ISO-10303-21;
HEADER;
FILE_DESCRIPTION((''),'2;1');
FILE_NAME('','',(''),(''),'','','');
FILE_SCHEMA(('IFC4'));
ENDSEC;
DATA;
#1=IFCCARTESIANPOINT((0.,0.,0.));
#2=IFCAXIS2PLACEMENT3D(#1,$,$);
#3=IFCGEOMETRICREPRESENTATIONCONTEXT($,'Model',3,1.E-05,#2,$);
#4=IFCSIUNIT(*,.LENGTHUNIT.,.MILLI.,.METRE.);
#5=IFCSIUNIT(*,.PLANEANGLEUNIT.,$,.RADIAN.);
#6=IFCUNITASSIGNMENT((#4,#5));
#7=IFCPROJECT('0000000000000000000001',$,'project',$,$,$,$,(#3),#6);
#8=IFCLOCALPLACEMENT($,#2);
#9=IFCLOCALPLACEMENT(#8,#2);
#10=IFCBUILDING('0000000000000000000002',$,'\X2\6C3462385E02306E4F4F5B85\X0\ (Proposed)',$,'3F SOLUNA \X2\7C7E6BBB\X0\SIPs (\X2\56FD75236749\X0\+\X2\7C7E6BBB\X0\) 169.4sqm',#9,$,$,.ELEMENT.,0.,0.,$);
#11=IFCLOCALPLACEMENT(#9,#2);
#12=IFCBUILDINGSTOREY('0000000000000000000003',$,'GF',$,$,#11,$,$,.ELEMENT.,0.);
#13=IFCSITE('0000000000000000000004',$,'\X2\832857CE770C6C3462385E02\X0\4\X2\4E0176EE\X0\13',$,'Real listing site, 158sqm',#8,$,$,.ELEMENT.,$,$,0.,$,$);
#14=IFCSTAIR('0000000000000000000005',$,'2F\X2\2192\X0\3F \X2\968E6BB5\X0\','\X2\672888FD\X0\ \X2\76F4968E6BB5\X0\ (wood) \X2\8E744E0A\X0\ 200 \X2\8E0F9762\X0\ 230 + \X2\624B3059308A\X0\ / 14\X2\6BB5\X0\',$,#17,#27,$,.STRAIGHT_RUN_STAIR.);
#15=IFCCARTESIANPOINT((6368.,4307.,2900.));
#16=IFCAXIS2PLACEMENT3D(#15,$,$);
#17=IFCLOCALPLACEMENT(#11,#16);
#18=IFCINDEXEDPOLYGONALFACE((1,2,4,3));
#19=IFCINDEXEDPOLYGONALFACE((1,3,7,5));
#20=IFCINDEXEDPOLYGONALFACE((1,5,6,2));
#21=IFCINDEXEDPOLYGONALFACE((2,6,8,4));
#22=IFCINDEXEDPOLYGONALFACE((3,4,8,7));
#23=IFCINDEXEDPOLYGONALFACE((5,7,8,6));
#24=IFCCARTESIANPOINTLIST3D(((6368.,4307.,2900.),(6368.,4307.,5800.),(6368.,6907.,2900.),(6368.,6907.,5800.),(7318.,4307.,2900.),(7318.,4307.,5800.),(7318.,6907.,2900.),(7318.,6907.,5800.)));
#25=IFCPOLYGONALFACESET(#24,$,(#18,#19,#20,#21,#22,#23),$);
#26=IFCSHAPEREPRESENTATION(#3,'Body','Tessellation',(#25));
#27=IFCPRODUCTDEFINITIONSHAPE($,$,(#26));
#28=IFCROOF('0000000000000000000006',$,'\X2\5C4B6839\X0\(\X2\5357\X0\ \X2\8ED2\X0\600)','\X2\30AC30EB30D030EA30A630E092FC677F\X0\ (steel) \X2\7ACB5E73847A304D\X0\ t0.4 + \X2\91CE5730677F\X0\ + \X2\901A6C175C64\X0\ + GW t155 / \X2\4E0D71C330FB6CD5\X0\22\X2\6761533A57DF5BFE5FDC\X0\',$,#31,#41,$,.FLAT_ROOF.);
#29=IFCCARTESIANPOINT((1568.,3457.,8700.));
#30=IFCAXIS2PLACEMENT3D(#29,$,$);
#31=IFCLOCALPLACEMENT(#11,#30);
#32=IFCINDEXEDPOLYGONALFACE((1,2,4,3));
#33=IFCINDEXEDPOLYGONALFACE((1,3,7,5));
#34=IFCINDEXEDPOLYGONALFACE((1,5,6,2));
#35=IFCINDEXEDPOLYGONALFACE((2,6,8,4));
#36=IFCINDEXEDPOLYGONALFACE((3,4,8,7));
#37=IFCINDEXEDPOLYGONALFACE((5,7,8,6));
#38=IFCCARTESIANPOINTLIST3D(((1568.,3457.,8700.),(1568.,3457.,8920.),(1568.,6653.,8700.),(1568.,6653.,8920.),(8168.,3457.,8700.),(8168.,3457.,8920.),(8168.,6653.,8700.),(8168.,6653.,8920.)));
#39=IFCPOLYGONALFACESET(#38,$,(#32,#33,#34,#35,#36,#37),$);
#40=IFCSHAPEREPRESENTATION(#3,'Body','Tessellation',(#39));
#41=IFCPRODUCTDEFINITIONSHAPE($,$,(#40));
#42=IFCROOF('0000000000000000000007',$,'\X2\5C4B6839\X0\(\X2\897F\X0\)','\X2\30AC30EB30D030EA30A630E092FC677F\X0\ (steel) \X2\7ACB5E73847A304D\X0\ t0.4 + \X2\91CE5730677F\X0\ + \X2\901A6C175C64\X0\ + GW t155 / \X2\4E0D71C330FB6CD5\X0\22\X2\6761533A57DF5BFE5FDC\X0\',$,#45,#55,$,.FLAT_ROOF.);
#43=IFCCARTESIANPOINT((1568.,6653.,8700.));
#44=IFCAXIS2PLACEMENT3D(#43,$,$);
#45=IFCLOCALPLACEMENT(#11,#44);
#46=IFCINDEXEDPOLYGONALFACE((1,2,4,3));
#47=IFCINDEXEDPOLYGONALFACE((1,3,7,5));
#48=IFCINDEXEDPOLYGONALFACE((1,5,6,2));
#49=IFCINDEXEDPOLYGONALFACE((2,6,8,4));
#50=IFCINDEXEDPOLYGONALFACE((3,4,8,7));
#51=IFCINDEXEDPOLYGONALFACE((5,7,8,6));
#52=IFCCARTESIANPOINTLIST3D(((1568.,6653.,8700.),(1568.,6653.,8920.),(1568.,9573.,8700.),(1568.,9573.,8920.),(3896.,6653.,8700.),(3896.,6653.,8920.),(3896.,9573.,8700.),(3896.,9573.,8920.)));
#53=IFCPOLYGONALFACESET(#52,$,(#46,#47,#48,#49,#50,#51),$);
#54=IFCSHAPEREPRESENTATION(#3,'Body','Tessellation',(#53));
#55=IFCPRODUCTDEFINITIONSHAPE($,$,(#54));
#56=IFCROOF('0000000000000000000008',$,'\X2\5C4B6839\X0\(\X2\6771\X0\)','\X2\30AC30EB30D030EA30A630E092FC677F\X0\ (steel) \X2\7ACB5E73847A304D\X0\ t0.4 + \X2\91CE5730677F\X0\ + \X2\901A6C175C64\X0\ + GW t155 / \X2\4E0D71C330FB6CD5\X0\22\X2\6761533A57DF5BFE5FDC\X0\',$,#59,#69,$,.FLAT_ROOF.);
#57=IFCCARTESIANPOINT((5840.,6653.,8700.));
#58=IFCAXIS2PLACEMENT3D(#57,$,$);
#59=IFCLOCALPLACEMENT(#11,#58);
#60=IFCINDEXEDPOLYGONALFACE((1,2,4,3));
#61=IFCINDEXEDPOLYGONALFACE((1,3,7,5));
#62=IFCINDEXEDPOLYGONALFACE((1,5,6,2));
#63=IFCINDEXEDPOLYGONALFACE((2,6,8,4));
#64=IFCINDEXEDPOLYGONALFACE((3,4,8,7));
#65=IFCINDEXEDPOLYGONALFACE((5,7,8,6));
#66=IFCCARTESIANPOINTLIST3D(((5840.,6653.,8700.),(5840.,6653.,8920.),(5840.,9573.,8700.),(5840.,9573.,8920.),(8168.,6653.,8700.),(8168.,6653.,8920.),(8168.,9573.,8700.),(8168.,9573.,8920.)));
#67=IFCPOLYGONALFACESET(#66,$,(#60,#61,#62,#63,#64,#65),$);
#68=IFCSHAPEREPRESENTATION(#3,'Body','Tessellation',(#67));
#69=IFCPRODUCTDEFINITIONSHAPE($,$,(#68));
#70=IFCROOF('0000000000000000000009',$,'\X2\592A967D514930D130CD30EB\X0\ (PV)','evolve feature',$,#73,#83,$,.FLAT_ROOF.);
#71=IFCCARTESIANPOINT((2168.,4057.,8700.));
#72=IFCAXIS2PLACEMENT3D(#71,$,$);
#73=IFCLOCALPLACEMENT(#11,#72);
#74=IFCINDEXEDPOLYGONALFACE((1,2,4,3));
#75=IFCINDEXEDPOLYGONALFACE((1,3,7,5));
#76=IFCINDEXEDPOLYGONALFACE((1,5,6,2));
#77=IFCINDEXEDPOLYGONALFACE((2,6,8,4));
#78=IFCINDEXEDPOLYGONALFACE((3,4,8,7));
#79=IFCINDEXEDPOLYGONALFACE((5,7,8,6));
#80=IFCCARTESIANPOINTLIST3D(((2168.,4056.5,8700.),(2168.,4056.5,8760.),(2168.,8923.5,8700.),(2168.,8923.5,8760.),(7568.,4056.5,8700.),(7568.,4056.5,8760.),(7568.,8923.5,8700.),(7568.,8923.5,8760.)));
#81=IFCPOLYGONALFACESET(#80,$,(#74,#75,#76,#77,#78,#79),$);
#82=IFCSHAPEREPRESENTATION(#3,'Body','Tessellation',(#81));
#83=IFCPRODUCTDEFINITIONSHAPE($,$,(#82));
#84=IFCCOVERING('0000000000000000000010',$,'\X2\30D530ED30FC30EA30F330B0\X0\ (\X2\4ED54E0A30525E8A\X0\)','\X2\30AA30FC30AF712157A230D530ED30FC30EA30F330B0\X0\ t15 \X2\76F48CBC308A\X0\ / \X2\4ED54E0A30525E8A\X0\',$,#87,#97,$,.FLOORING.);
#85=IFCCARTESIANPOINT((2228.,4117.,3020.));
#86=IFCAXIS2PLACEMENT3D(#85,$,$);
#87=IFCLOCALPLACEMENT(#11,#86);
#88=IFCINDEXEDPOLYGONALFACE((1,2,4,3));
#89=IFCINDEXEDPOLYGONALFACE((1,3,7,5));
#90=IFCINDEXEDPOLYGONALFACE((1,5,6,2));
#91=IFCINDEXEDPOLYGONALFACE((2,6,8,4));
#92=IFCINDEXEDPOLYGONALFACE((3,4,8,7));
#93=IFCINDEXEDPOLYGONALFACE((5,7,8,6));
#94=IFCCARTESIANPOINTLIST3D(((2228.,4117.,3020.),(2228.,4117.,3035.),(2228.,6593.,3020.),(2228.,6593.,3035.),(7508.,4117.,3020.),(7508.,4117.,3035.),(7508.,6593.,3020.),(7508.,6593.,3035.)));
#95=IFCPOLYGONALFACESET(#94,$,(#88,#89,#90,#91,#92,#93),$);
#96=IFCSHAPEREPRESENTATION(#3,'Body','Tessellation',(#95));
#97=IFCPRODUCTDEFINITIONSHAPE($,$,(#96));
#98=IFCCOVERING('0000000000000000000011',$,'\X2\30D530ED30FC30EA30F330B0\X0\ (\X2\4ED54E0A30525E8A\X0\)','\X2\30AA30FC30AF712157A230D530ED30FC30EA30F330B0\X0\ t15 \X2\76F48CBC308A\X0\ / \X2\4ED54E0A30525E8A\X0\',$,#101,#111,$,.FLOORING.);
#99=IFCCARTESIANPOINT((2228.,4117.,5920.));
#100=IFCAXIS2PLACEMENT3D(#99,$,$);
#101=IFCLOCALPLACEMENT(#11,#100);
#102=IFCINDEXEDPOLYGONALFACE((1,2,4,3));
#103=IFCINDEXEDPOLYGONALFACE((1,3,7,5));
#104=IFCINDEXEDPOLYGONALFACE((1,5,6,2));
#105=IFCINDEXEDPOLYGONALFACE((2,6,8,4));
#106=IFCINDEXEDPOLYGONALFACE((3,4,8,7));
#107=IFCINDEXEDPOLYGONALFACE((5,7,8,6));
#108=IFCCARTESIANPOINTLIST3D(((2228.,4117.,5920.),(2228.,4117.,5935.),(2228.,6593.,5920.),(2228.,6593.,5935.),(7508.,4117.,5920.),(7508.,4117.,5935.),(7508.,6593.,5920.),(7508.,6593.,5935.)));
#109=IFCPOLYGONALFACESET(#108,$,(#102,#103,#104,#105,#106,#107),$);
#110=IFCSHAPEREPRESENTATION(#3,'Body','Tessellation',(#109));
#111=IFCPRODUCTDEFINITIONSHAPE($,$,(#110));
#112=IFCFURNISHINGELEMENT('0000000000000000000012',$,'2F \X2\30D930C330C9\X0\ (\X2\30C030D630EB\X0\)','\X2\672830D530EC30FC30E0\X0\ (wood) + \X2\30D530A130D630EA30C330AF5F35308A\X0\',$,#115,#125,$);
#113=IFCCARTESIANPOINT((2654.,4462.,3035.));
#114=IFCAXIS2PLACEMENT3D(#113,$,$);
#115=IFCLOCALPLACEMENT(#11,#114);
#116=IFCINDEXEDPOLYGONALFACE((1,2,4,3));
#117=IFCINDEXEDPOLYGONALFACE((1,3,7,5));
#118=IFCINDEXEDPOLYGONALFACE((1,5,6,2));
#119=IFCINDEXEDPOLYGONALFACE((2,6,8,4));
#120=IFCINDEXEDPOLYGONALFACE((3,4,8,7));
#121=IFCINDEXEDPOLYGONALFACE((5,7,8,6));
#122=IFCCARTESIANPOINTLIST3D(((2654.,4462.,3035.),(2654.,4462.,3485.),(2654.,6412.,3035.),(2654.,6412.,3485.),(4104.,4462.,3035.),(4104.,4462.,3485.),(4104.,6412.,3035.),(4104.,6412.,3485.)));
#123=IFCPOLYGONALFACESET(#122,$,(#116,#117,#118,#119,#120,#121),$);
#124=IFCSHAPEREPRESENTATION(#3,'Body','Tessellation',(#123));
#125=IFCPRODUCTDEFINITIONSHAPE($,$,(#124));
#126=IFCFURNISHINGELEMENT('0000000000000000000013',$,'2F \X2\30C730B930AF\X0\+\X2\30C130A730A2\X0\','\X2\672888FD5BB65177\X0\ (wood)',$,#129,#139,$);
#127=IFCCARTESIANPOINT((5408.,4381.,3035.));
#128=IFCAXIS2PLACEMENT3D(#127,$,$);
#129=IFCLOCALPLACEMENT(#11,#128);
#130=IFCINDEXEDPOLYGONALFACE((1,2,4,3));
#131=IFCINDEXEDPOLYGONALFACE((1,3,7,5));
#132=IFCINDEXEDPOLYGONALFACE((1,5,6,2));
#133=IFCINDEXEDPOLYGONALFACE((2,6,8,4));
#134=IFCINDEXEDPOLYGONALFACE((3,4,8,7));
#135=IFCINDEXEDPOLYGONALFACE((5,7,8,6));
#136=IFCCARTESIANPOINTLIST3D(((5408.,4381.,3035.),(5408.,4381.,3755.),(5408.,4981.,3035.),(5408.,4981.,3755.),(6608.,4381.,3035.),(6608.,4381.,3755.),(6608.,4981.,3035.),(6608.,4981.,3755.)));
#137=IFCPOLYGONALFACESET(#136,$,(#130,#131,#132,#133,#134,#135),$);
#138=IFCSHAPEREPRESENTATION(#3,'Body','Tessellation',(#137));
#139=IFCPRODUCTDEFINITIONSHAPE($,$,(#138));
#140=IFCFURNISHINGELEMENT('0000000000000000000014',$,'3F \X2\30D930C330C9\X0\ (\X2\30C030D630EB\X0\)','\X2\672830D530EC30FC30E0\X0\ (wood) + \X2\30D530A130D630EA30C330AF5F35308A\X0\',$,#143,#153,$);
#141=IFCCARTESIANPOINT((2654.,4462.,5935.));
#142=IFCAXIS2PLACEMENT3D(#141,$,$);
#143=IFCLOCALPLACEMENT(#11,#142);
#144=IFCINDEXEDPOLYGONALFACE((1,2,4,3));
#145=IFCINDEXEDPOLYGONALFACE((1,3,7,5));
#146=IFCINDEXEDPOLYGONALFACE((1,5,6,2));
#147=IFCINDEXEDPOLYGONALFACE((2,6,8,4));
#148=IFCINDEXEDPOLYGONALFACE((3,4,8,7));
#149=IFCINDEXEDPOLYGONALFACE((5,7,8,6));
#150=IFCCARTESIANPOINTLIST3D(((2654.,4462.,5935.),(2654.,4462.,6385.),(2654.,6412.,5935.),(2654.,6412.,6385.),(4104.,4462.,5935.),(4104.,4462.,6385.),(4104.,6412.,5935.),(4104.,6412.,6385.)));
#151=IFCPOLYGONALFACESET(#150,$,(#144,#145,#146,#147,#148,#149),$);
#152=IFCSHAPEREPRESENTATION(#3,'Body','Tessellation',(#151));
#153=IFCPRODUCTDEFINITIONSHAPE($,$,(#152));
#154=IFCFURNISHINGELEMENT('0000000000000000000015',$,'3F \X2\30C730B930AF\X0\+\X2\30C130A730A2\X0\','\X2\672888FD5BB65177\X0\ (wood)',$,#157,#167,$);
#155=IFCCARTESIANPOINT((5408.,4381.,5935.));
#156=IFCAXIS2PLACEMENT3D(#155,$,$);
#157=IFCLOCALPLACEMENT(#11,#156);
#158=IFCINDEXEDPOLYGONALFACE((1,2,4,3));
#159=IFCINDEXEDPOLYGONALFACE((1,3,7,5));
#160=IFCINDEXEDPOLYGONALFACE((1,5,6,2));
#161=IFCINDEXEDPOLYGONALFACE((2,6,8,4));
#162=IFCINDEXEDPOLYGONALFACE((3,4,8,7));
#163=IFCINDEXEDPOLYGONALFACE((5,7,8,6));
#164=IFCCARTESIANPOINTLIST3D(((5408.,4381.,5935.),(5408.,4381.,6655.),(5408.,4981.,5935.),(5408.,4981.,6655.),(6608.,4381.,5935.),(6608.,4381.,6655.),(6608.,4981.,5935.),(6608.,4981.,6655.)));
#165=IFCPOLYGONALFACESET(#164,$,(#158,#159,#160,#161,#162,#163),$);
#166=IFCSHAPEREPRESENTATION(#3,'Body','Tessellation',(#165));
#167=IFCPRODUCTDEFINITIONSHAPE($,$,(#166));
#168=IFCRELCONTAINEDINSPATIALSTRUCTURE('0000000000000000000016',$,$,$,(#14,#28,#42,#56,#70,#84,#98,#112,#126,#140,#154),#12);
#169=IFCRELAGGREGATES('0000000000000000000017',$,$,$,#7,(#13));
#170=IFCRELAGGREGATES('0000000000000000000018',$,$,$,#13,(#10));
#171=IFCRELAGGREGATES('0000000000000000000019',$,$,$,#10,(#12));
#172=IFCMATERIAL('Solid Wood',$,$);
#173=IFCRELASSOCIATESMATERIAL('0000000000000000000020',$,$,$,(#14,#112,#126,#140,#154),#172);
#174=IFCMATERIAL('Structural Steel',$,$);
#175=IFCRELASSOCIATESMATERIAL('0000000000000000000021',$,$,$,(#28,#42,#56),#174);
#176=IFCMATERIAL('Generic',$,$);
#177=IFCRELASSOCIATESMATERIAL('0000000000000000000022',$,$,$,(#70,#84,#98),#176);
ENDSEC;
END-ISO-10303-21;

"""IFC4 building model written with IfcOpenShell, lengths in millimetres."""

from ifc_helpers import new_model, si_unit, frame, frame_2d, origin, place, context, project, spatial, rectangle, extrude, material, element, save


model = new_model("IFC4")

# Units and contexts
model_context = context("Model", 3, precision=1e-05, world=origin())
ifc_project = project(units=[si_unit("LENGTHUNIT", "METRE", prefix="MILLI"), si_unit("PLANEANGLEUNIT", "RADIAN")], contexts=[model_context])

# Site, building, storey
site_placement = place(None, origin())
site = spatial("IfcSite", under=ifc_project, at=site_placement, Name="茨城県水戸市4丁目13", ObjectType="Real listing site, 158sqm", CompositionType="ELEMENT", RefElevation=0.0)
building_placement = place(site_placement, origin())
building = spatial("IfcBuilding", under=site, at=building_placement, Name="水戸市の住宅 (Proposed)", ObjectType="3F SOLUNA 籾殻SIPs (国産杉+籾殻) 169.4sqm", CompositionType="ELEMENT", ElevationOfRefHeight=0.0, ElevationOfTerrain=0.0)
storey_placement = place(building_placement, origin())
storey = spatial("IfcBuildingStorey", under=building, at=storey_placement, Name="GF", CompositionType="ELEMENT", Elevation=0.0)

# Shared definitions
ifc_material_1 = material(Name="Solid Wood")

# Stair
stair_placement = place(storey_placement, frame((6368.0, 4307.0, 2900.0)))
element("IfcStair", 1, at=stair_placement, inside=storey, material=ifc_material_1, Name="2F→3F 階段", Description="木製 直階段 (wood) 蹴上 200 踏面 230 + 手すり / 14段", PredefinedType="STRAIGHT_RUN_STAIR", context=model_context, shape_type="SweptSolid", body=[
    extrude(rectangle(XDim=950.0, YDim=2600.0, at=frame_2d((475.0, 1300.0))), frame((6368.0, 4307.0, 2900.0)), (0.0, 0.0, 1.0), 2900.0),
])

# Roofs
ifc_material_2 = material(Name="Structural Steel")
roof_1_placement = place(storey_placement, frame((1568.0, 3457.0, 8700.0)))
element("IfcRoof", 2, at=roof_1_placement, inside=storey, material=ifc_material_2, Name="屋根(南 軒600)", Description="ガルバリウム鋼板 (steel) 立平葺き t0.4 + 野地板 + 通気層 + GW t155 / 不燃・法22条区域対応", PredefinedType="FLAT_ROOF", context=model_context, shape_type="SweptSolid", body=[
    extrude(rectangle(XDim=6600.0, YDim=3196.0, at=frame_2d((3300.0, 1598.0))), frame((1568.0, 3457.0, 8700.0)), (0.0, 0.0, 1.0), 220.0),
])
roof_2_placement = place(storey_placement, frame((1568.0, 6653.0, 8700.0)))
element("IfcRoof", 3, at=roof_2_placement, inside=storey, material=ifc_material_2, Name="屋根(西)", Description="ガルバリウム鋼板 (steel) 立平葺き t0.4 + 野地板 + 通気層 + GW t155 / 不燃・法22条区域対応", PredefinedType="FLAT_ROOF", context=model_context, shape_type="SweptSolid", body=[
    extrude(rectangle(XDim=2328.0, YDim=2920.0, at=frame_2d((1164.0, 1460.0))), frame((1568.0, 6653.0, 8700.0)), (0.0, 0.0, 1.0), 220.0),
])
roof_3_placement = place(storey_placement, frame((5840.0, 6653.0, 8700.0)))
element("IfcRoof", 4, at=roof_3_placement, inside=storey, material=ifc_material_2, Name="屋根(東)", Description="ガルバリウム鋼板 (steel) 立平葺き t0.4 + 野地板 + 通気層 + GW t155 / 不燃・法22条区域対応", PredefinedType="FLAT_ROOF", context=model_context, shape_type="SweptSolid", body=[
    extrude(rectangle(XDim=2328.0, YDim=2920.0, at=frame_2d((1164.0, 1460.0))), frame((5840.0, 6653.0, 8700.0)), (0.0, 0.0, 1.0), 220.0),
])
ifc_material_3 = material(Name="Generic")
roof_4_placement = place(storey_placement, frame((2168.0, 4057.0, 8700.0)))
element("IfcRoof", 5, at=roof_4_placement, inside=storey, material=ifc_material_3, Name="太陽光パネル (PV)", Description="evolve feature", PredefinedType="FLAT_ROOF", context=model_context, shape_type="SweptSolid", body=[
    extrude(rectangle(XDim=5400.0, YDim=4867.0, at=frame_2d((2700.0, 2433.0))), frame((2168.0, 4057.0, 8700.0)), (0.0, 0.0, 1.0), 60.0),
])

# Coverings
covering_1_placement = place(storey_placement, frame((2228.0, 4117.0, 3020.0)))
element("IfcCovering", 6, at=covering_1_placement, inside=storey, material=ifc_material_3, Name="フローリング (仕上げ床)", Description="オーク無垢フローリング t15 直貼り / 仕上げ床", PredefinedType="FLOORING", context=model_context, shape_type="SweptSolid", body=[
    extrude(rectangle(XDim=5280.0, YDim=2476.0, at=frame_2d((2640.0, 1238.0))), frame((2228.0, 4117.0, 3020.0)), (0.0, 0.0, 1.0), 15.0),
])
covering_2_placement = place(storey_placement, frame((2228.0, 4117.0, 5920.0)))
element("IfcCovering", 7, at=covering_2_placement, inside=storey, material=ifc_material_3, Name="フローリング (仕上げ床)", Description="オーク無垢フローリング t15 直貼り / 仕上げ床", PredefinedType="FLOORING", context=model_context, shape_type="SweptSolid", body=[
    extrude(rectangle(XDim=5280.0, YDim=2476.0, at=frame_2d((2640.0, 1238.0))), frame((2228.0, 4117.0, 5920.0)), (0.0, 0.0, 1.0), 15.0),
])

# Furnishing elements
furnishing_1_placement = place(storey_placement, frame((2654.0, 4462.0, 3035.0)))
element("IfcFurnishingElement", 8, at=furnishing_1_placement, inside=storey, material=ifc_material_1, Name="2F ベッド (ダブル)", Description="木フレーム (wood) + ファブリック張り", context=model_context, shape_type="SweptSolid", body=[
    extrude(rectangle(XDim=1450.0, YDim=1950.0, at=frame_2d((725.0, 975.0))), frame((2654.0, 4462.0, 3035.0)), (0.0, 0.0, 1.0), 450.0),
])
furnishing_2_placement = place(storey_placement, frame((5408.0, 4381.0, 3035.0)))
element("IfcFurnishingElement", 9, at=furnishing_2_placement, inside=storey, material=ifc_material_1, Name="2F デスク+チェア", Description="木製家具 (wood)", context=model_context, shape_type="SweptSolid", body=[
    extrude(rectangle(XDim=1200.0, YDim=600.0, at=frame_2d((600.0, 300.0))), frame((5408.0, 4381.0, 3035.0)), (0.0, 0.0, 1.0), 720.0),
])
furnishing_3_placement = place(storey_placement, frame((2654.0, 4462.0, 5935.0)))
element("IfcFurnishingElement", 10, at=furnishing_3_placement, inside=storey, material=ifc_material_1, Name="3F ベッド (ダブル)", Description="木フレーム (wood) + ファブリック張り", context=model_context, shape_type="SweptSolid", body=[
    extrude(rectangle(XDim=1450.0, YDim=1950.0, at=frame_2d((725.0, 975.0))), frame((2654.0, 4462.0, 5935.0)), (0.0, 0.0, 1.0), 450.0),
])
furnishing_4_placement = place(storey_placement, frame((5408.0, 4381.0, 5935.0)))
element("IfcFurnishingElement", 11, at=furnishing_4_placement, inside=storey, material=ifc_material_1, Name="3F デスク+チェア", Description="木製家具 (wood)", context=model_context, shape_type="SweptSolid", body=[
    extrude(rectangle(XDim=1200.0, YDim=600.0, at=frame_2d((600.0, 300.0))), frame((5408.0, 4381.0, 5935.0)), (0.0, 0.0, 1.0), 720.0),
])

save(model, "model.ifc")
